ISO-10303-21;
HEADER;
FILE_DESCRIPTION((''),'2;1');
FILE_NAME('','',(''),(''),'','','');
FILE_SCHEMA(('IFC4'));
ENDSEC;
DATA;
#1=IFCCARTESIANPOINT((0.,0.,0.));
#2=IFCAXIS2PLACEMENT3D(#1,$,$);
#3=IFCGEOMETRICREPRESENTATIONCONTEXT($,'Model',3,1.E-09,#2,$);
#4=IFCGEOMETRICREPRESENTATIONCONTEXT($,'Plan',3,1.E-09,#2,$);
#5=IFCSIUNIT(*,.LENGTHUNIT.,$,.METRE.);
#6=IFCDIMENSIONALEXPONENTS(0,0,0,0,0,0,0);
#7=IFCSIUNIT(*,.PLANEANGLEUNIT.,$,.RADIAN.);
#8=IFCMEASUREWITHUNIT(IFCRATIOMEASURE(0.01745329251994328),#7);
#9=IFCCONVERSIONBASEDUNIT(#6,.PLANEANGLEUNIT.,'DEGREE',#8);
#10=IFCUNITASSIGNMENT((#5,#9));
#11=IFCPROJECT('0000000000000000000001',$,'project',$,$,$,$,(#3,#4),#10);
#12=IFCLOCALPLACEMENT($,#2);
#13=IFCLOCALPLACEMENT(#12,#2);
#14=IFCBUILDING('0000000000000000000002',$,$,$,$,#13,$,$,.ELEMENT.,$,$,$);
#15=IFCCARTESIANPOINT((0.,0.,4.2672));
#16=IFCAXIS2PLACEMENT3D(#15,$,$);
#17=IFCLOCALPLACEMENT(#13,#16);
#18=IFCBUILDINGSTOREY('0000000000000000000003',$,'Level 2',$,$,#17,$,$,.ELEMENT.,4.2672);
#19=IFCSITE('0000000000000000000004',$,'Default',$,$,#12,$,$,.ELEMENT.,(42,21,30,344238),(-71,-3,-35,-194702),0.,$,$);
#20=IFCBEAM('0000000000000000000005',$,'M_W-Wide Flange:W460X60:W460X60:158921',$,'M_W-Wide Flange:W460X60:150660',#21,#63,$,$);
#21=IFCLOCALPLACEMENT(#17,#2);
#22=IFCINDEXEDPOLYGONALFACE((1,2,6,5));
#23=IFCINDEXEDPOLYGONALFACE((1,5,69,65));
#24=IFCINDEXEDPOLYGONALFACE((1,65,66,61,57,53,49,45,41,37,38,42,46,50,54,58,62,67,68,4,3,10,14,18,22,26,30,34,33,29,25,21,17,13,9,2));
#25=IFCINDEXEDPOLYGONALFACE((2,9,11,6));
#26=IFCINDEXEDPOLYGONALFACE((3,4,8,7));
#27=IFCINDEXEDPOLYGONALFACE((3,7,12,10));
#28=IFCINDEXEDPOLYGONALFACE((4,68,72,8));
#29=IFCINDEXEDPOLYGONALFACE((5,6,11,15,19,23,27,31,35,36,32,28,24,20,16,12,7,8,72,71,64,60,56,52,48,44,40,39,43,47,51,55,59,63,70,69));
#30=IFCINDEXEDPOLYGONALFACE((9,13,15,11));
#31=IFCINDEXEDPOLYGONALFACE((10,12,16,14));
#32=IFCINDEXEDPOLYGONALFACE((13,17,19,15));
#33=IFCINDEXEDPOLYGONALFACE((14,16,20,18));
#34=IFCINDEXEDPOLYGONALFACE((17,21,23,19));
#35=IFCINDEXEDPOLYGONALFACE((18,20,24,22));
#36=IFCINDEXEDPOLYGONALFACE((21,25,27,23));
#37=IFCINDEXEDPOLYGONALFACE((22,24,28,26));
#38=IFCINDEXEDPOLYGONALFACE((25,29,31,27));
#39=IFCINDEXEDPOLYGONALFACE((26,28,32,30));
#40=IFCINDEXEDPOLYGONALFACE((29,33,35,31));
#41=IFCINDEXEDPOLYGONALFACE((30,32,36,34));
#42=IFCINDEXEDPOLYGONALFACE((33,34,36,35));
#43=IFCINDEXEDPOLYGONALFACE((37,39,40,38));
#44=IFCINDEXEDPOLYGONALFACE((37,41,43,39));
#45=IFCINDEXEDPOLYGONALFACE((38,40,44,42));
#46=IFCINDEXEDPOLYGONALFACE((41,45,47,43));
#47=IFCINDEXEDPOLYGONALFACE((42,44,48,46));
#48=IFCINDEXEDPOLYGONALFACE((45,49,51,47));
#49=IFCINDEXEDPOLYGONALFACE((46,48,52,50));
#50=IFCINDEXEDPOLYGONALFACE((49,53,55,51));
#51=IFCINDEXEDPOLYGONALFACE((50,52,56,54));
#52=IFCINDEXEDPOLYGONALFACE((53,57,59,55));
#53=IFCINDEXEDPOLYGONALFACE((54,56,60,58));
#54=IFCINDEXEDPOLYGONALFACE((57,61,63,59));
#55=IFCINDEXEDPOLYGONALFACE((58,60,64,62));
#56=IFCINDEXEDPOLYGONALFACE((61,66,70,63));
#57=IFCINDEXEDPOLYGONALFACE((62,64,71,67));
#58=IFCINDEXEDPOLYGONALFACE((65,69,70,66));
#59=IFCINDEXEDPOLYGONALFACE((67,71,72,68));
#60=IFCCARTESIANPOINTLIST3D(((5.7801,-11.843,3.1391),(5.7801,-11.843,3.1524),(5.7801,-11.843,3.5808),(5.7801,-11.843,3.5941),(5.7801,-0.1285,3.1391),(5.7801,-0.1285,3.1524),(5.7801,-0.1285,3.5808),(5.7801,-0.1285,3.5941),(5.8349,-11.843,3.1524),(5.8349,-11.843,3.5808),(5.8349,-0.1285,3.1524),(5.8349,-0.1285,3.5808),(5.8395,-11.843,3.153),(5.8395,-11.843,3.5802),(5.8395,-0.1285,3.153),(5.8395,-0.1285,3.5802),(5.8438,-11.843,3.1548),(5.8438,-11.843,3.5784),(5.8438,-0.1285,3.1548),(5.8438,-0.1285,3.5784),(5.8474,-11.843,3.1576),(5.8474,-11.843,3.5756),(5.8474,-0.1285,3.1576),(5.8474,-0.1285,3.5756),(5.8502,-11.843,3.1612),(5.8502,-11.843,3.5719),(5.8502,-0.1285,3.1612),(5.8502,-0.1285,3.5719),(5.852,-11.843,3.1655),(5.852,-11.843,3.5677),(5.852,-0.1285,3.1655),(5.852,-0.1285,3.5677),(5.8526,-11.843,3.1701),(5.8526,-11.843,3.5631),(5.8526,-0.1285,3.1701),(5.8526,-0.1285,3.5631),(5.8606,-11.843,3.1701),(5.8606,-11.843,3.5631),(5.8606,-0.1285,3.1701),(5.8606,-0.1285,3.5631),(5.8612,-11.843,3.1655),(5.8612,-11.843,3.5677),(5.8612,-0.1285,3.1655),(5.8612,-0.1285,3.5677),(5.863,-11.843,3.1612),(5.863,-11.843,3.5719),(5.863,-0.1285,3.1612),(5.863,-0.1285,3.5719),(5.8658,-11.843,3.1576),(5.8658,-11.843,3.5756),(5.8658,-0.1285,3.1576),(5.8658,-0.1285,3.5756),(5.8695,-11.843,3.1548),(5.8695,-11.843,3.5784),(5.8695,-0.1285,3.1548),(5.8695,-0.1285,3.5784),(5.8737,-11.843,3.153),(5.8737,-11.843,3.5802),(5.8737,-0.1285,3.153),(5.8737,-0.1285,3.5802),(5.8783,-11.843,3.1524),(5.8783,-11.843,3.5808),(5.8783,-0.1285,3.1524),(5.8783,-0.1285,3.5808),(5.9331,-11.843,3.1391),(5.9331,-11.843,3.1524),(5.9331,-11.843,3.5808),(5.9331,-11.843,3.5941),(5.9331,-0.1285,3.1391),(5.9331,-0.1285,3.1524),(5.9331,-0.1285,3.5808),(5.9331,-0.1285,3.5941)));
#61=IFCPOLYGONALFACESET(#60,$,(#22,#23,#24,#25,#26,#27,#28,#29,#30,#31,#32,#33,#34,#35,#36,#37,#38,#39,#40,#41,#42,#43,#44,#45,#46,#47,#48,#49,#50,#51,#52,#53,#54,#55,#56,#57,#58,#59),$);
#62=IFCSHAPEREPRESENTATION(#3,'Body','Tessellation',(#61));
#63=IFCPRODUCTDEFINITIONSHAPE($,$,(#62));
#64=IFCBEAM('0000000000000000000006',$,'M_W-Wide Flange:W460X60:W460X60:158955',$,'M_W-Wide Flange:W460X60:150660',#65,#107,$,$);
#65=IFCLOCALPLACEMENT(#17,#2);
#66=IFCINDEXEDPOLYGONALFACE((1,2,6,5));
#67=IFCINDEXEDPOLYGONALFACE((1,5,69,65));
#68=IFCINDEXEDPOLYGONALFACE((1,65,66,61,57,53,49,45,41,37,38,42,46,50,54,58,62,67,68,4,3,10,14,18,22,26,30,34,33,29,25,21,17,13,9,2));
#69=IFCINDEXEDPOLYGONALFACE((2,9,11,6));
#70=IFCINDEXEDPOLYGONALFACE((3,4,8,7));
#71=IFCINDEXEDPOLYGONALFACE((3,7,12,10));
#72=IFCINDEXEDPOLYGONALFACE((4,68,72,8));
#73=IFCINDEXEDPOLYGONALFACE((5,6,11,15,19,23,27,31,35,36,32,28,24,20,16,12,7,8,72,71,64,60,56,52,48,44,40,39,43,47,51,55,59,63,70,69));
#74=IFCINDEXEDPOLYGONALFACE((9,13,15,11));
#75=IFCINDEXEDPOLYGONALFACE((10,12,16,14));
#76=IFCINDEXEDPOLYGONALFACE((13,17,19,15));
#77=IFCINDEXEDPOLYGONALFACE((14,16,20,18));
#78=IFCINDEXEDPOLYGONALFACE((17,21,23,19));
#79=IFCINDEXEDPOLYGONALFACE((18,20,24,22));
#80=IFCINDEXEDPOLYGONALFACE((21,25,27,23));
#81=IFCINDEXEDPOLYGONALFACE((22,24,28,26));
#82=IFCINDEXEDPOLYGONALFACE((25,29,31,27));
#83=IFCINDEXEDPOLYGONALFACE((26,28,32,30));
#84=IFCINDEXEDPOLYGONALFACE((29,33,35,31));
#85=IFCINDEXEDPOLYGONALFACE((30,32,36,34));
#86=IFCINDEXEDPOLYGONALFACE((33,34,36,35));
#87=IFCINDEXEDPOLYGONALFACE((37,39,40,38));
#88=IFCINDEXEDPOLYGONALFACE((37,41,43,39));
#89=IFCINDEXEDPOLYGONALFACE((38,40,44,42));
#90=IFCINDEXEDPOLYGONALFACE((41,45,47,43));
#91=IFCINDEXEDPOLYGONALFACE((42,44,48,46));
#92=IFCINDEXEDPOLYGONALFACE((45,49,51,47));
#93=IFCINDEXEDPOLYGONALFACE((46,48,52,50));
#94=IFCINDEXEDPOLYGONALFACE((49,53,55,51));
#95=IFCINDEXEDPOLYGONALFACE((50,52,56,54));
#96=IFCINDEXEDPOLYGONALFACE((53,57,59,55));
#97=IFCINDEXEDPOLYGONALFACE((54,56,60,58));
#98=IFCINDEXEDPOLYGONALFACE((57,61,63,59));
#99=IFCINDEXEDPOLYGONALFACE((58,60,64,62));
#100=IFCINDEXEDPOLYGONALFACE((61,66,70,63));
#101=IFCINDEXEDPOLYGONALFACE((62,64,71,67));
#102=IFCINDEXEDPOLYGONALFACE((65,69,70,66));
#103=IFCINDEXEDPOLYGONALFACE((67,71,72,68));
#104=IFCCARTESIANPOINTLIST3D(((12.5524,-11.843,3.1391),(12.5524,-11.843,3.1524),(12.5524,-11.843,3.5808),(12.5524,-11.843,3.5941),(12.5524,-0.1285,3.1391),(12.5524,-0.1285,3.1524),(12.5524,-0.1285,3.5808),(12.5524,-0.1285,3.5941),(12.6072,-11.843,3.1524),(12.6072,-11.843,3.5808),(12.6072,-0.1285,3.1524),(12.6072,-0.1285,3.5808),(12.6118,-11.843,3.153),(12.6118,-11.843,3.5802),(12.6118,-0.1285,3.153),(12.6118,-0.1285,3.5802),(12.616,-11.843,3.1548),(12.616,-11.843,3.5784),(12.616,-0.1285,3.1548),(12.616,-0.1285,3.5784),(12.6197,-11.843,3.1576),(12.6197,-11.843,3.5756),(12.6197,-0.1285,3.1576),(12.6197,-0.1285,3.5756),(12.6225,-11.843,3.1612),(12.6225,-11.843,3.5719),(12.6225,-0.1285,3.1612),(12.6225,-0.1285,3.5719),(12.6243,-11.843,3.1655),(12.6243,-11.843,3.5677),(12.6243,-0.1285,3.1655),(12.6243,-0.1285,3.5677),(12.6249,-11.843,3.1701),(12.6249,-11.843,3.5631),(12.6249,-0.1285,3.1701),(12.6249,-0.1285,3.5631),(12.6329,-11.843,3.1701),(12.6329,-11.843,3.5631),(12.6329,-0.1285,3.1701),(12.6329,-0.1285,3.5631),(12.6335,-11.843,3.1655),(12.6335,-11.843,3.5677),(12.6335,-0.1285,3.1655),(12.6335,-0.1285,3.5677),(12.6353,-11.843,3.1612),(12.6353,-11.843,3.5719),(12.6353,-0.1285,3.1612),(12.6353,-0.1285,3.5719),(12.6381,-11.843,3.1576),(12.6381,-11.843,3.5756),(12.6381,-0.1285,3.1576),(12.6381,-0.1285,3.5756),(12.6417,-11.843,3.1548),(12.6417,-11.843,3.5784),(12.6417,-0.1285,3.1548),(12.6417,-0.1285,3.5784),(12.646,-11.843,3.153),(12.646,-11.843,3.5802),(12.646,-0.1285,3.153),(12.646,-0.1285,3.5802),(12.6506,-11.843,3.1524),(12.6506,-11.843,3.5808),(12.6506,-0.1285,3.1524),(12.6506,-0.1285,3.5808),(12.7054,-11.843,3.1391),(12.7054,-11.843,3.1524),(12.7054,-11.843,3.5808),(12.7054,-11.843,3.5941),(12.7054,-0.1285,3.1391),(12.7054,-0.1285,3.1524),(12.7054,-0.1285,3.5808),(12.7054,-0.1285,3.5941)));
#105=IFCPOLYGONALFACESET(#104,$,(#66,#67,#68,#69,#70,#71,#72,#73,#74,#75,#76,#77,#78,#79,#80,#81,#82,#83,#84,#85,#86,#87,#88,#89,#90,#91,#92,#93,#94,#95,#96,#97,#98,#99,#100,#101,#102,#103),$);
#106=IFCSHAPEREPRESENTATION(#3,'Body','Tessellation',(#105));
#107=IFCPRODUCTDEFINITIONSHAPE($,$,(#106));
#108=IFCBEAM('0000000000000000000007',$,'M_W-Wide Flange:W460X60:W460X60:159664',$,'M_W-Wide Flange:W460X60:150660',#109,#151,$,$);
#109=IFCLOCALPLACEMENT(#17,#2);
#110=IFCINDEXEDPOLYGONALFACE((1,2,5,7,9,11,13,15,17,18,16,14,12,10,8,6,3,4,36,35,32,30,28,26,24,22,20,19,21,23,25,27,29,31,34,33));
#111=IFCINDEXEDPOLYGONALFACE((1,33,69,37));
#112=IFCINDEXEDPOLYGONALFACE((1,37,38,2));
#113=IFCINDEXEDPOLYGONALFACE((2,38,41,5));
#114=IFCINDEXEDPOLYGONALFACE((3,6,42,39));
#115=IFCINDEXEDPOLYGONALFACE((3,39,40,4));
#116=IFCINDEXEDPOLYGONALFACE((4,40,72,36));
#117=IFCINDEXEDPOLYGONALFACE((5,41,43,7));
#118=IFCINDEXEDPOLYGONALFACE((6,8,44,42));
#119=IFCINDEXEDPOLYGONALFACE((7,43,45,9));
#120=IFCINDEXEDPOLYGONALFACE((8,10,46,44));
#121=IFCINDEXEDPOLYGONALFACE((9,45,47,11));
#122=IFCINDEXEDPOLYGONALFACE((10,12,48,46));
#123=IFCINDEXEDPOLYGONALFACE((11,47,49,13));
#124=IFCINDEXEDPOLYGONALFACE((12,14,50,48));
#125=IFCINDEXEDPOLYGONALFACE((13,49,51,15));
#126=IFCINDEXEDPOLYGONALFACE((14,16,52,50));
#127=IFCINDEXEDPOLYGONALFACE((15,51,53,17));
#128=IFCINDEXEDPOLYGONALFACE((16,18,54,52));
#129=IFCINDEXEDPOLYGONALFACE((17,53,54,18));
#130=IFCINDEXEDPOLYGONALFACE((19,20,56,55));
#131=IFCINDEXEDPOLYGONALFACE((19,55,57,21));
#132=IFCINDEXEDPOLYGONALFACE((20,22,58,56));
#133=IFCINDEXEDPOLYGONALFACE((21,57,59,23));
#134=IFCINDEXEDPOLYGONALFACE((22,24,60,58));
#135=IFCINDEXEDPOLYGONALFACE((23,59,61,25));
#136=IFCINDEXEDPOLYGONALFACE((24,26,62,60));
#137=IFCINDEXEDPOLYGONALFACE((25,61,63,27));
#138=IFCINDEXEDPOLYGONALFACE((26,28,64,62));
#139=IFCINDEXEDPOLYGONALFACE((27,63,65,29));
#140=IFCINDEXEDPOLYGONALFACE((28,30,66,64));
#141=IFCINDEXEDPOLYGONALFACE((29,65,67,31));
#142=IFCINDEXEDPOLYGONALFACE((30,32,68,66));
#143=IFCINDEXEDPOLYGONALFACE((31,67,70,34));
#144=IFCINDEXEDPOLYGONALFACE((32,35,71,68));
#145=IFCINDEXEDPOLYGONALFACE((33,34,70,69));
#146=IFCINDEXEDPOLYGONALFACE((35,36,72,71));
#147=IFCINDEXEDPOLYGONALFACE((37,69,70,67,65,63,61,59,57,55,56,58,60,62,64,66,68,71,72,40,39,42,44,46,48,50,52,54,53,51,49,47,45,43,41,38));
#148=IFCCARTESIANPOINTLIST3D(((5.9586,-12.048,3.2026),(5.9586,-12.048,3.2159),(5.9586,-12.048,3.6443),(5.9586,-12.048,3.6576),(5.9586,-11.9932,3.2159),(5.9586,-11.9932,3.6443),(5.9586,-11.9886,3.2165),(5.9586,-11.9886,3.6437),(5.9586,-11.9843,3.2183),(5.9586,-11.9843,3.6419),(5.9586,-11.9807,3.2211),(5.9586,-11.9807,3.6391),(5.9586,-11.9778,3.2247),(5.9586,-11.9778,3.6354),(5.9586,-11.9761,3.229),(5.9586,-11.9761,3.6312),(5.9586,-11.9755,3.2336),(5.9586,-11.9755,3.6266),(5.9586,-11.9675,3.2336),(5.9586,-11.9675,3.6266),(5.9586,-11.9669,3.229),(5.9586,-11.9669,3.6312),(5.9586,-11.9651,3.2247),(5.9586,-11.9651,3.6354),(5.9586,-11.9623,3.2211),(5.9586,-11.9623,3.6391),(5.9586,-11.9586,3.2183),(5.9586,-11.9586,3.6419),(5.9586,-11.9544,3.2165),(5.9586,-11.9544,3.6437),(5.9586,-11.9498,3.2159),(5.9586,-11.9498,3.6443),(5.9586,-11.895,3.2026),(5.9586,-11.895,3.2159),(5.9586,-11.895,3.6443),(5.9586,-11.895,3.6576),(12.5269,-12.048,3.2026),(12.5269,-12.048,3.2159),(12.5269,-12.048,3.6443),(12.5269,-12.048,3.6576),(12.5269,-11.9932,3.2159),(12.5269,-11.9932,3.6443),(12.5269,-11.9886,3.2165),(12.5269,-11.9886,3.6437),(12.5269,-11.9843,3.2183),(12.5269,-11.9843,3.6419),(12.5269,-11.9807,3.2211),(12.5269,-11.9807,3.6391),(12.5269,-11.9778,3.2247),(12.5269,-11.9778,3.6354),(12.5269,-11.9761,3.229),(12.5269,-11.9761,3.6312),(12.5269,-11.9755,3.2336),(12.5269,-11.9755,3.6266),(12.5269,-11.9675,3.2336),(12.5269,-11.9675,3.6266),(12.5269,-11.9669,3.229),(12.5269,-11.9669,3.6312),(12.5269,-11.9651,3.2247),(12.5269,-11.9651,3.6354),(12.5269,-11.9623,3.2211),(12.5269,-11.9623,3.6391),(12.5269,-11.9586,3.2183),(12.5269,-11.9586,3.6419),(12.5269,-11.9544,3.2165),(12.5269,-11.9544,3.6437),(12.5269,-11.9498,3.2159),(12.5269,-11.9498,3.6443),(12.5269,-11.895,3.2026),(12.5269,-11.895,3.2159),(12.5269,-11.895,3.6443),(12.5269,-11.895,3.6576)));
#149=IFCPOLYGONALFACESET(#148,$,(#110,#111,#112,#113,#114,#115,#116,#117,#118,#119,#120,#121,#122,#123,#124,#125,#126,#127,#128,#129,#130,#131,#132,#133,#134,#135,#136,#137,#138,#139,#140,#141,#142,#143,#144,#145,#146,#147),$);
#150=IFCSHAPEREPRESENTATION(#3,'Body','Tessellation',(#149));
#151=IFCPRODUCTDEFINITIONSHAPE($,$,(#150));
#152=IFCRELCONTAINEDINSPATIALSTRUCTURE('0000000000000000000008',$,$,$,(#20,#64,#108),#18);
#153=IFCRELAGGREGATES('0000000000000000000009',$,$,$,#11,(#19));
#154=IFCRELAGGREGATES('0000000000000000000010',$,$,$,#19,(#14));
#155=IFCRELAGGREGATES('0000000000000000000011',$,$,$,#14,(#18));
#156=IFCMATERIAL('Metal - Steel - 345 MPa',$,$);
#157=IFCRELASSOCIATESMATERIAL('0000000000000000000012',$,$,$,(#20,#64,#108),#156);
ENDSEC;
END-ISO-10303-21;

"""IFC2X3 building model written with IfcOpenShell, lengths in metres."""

from ifc_helpers import new_model, entity, si_unit, converted_unit, frame, frame_2d, origin, place, context, project, spatial, polyline, circle_curve, parameter, trimmed, segment, composite_curve, outline, extrude, material, element, save


model = new_model("IFC2X3")

# Units and contexts
model_context = context("Model", 3, precision=1e-09, world=origin())
plan_context = context("Plan", 3, precision=1e-09, world=origin())
ifc_project = project(units=[si_unit("LENGTHUNIT", "METRE"), converted_unit("PLANEANGLEUNIT", "DEGREE", entity("IfcRatioMeasure", 0.01745329251994328), si_unit("PLANEANGLEUNIT", "RADIAN"), dimensions=[0, 0, 0, 0, 0, 0, 0])], contexts=[model_context, plan_context])

# Site, building, storey
site_placement = place(None, origin())
site = spatial("IfcSite", under=ifc_project, at=site_placement, Name="Default", CompositionType="ELEMENT", RefLatitude=(42, 21, 30, 344238), RefLongitude=(-71, -3, -35, -194702), RefElevation=0.0)
building_placement = place(site_placement, origin())
building = spatial("IfcBuilding", under=site, at=building_placement, CompositionType="ELEMENT")
storey_placement = place(building_placement, frame((0.0, 0.0, 4.2672)))
storey = spatial("IfcBuildingStorey", under=building, at=storey_placement, Name="Level 2", CompositionType="ELEMENT", Elevation=4.2672)

# Shared definitions
ifc_material = material(Name="Metal - Steel - 345 MPa")

# Beams
beam_1_placement = place(storey_placement, frame((5.8566, 0.0, 3.6576), z_axis=(0.0, 0.0, 1.0), x_axis=(-1.0, 0.0, 0.0)))
element("IfcBeam", 1, at=beam_1_placement, inside=storey, material=ifc_material, Name="M_W-Wide Flange:W460X60:W460X60:158921", ObjectType="M_W-Wide Flange:W460X60:150660", context=model_context, shape_type="SweptSolid", body=[
    extrude(outline(composite_curve([segment(polyline([(0.2142, -0.0765), (0.2275, -0.0765)]), True, "CONTINUOUS"), segment(polyline([(0.2275, -0.0765), (0.2275, 0.0765)]), True, "CONTINUOUS"), segment(polyline([(0.2275, 0.0765), (0.2142, 0.0765)]), True, "CONTINUOUS"), segment(polyline([(0.2142, 0.0765), (0.2142, 0.0217)]), True, "CONTINUOUS"), segment(trimmed(circle_curve(frame_2d((0.1965, 0.0217), x_axis=(0.0, 1.0)), 0.0177), [parameter(180.0)], [parameter(270.0)], True, "PARAMETER"), False, "CONTINUOUS"), segment(polyline([(0.1965, 0.004), (-0.1965, 0.004)]), True, "CONTINUOUS"), segment(trimmed(circle_curve(frame_2d((-0.1965, 0.0217), x_axis=(0.0, 1.0)), 0.0177), [parameter(90.0)], [parameter(180.0)], True, "PARAMETER"), False, "CONTINUOUS"), segment(polyline([(-0.2142, 0.0217), (-0.2142, 0.0765)]), True, "CONTINUOUS"), segment(polyline([(-0.2142, 0.0765), (-0.2275, 0.0765)]), True, "CONTINUOUS"), segment(polyline([(-0.2275, 0.0765), (-0.2275, -0.0765)]), True, "CONTINUOUS"), segment(polyline([(-0.2275, -0.0765), (-0.2142, -0.0765)]), True, "CONTINUOUS"), segment(polyline([(-0.2142, -0.0765), (-0.2142, -0.0217)]), True, "CONTINUOUS"), segment(trimmed(circle_curve(frame_2d((-0.1965, -0.0217), x_axis=(0.0, 1.0)), 0.0177), [parameter(360.0)], [parameter(90.0)], True, "PARAMETER"), False, "CONTINUOUS"), segment(polyline([(-0.1965, -0.004), (0.1965, -0.004)]), True, "CONTINUOUS"), segment(trimmed(circle_curve(frame_2d((0.1965, -0.0217), x_axis=(0.0, 1.0)), 0.0177), [parameter(270.0)], [parameter(0.0)], True, "PARAMETER"), False, "CONTINUOUS"), segment(polyline([(0.2142, -0.0217), (0.2142, -0.0765)]), True, "CONTINUOUS")], self_intersect=False)), frame((0.0, 11.843, -0.291), z_axis=(0.0, -1.0, 0.0), x_axis=(0.0, 0.0, -1.0)), (0.0, 0.0, 1.0), 11.7145),
])
beam_2_placement = place(storey_placement, frame((12.6289, 0.0, 3.6576), z_axis=(0.0, 0.0, 1.0), x_axis=(-1.0, 0.0, 0.0)))
element("IfcBeam", 2, at=beam_2_placement, inside=storey, material=ifc_material, Name="M_W-Wide Flange:W460X60:W460X60:158955", ObjectType="M_W-Wide Flange:W460X60:150660", context=model_context, shape_type="SweptSolid", body=[
    extrude(outline(composite_curve([segment(polyline([(0.2142, -0.0765), (0.2275, -0.0765)]), True, "CONTINUOUS"), segment(polyline([(0.2275, -0.0765), (0.2275, 0.0765)]), True, "CONTINUOUS"), segment(polyline([(0.2275, 0.0765), (0.2142, 0.0765)]), True, "CONTINUOUS"), segment(polyline([(0.2142, 0.0765), (0.2142, 0.0217)]), True, "CONTINUOUS"), segment(trimmed(circle_curve(frame_2d((0.1965, 0.0217), x_axis=(0.0, 1.0)), 0.0177), [parameter(180.0)], [parameter(270.0)], True, "PARAMETER"), False, "CONTINUOUS"), segment(polyline([(0.1965, 0.004), (-0.1965, 0.004)]), True, "CONTINUOUS"), segment(trimmed(circle_curve(frame_2d((-0.1965, 0.0217), x_axis=(0.0, 1.0)), 0.0177), [parameter(90.0)], [parameter(180.0)], True, "PARAMETER"), False, "CONTINUOUS"), segment(polyline([(-0.2142, 0.0217), (-0.2142, 0.0765)]), True, "CONTINUOUS"), segment(polyline([(-0.2142, 0.0765), (-0.2275, 0.0765)]), True, "CONTINUOUS"), segment(polyline([(-0.2275, 0.0765), (-0.2275, -0.0765)]), True, "CONTINUOUS"), segment(polyline([(-0.2275, -0.0765), (-0.2142, -0.0765)]), True, "CONTINUOUS"), segment(polyline([(-0.2142, -0.0765), (-0.2142, -0.0217)]), True, "CONTINUOUS"), segment(trimmed(circle_curve(frame_2d((-0.1965, -0.0217), x_axis=(0.0, 1.0)), 0.0177), [parameter(360.0)], [parameter(90.0)], True, "PARAMETER"), False, "CONTINUOUS"), segment(polyline([(-0.1965, -0.004), (0.1965, -0.004)]), True, "CONTINUOUS"), segment(trimmed(circle_curve(frame_2d((0.1965, -0.0217), x_axis=(0.0, 1.0)), 0.0177), [parameter(270.0)], [parameter(0.0)], True, "PARAMETER"), False, "CONTINUOUS"), segment(polyline([(0.2142, -0.0217), (0.2142, -0.0765)]), True, "CONTINUOUS")], self_intersect=False)), frame((0.0, 11.843, -0.291), z_axis=(0.0, -1.0, 0.0), x_axis=(0.0, 0.0, -1.0)), (0.0, 0.0, 1.0), 11.7145),
])
beam_3_placement = place(storey_placement, frame((12.6289, -11.9715, 3.6576), z_axis=(0.0, 0.0, 1.0), x_axis=(0.0, 1.0, 0.0)))
element("IfcBeam", 3, at=beam_3_placement, inside=storey, material=ifc_material, Name="M_W-Wide Flange:W460X60:W460X60:159664", ObjectType="M_W-Wide Flange:W460X60:150660", context=model_context, shape_type="SweptSolid", body=[
    extrude(outline(composite_curve([segment(polyline([(0.2142, -0.0765), (0.2275, -0.0765)]), True, "CONTINUOUS"), segment(polyline([(0.2275, -0.0765), (0.2275, 0.0765)]), True, "CONTINUOUS"), segment(polyline([(0.2275, 0.0765), (0.2142, 0.0765)]), True, "CONTINUOUS"), segment(polyline([(0.2142, 0.0765), (0.2142, 0.0217)]), True, "CONTINUOUS"), segment(trimmed(circle_curve(frame_2d((0.1965, 0.0217), x_axis=(1.0, 0.0)), 0.0177), [parameter(270.0)], [parameter(360.0)], True, "PARAMETER"), False, "CONTINUOUS"), segment(polyline([(0.1965, 0.004), (-0.1965, 0.004)]), True, "CONTINUOUS"), segment(trimmed(circle_curve(frame_2d((-0.1965, 0.0217), x_axis=(0.0, -1.0)), 0.0177), [parameter(270.0)], [parameter(360.0)], True, "PARAMETER"), False, "CONTINUOUS"), segment(polyline([(-0.2142, 0.0217), (-0.2142, 0.0765)]), True, "CONTINUOUS"), segment(polyline([(-0.2142, 0.0765), (-0.2275, 0.0765)]), True, "CONTINUOUS"), segment(polyline([(-0.2275, 0.0765), (-0.2275, -0.0765)]), True, "CONTINUOUS"), segment(polyline([(-0.2275, -0.0765), (-0.2142, -0.0765)]), True, "CONTINUOUS"), segment(polyline([(-0.2142, -0.0765), (-0.2142, -0.0217)]), True, "CONTINUOUS"), segment(trimmed(circle_curve(frame_2d((-0.1965, -0.0217), x_axis=(-1.0, 0.0)), 0.0177), [parameter(270.0)], [parameter(360.0)], True, "PARAMETER"), False, "CONTINUOUS"), segment(polyline([(-0.1965, -0.004), (0.1965, -0.004)]), True, "CONTINUOUS"), segment(trimmed(circle_curve(frame_2d((0.1965, -0.0217), x_axis=(0.0, 1.0)), 0.0177), [parameter(270.0)], [parameter(0.0)], True, "PARAMETER"), False, "CONTINUOUS"), segment(polyline([(0.2142, -0.0217), (0.2142, -0.0765)]), True, "CONTINUOUS")], self_intersect=False)), frame((0.0, 6.6703, -0.2275), z_axis=(0.0, -1.0, 0.0), x_axis=(0.0, 0.0, -1.0)), (0.0, 0.0, 1.0), 6.5683),
])

save(model, "model.ifc")
